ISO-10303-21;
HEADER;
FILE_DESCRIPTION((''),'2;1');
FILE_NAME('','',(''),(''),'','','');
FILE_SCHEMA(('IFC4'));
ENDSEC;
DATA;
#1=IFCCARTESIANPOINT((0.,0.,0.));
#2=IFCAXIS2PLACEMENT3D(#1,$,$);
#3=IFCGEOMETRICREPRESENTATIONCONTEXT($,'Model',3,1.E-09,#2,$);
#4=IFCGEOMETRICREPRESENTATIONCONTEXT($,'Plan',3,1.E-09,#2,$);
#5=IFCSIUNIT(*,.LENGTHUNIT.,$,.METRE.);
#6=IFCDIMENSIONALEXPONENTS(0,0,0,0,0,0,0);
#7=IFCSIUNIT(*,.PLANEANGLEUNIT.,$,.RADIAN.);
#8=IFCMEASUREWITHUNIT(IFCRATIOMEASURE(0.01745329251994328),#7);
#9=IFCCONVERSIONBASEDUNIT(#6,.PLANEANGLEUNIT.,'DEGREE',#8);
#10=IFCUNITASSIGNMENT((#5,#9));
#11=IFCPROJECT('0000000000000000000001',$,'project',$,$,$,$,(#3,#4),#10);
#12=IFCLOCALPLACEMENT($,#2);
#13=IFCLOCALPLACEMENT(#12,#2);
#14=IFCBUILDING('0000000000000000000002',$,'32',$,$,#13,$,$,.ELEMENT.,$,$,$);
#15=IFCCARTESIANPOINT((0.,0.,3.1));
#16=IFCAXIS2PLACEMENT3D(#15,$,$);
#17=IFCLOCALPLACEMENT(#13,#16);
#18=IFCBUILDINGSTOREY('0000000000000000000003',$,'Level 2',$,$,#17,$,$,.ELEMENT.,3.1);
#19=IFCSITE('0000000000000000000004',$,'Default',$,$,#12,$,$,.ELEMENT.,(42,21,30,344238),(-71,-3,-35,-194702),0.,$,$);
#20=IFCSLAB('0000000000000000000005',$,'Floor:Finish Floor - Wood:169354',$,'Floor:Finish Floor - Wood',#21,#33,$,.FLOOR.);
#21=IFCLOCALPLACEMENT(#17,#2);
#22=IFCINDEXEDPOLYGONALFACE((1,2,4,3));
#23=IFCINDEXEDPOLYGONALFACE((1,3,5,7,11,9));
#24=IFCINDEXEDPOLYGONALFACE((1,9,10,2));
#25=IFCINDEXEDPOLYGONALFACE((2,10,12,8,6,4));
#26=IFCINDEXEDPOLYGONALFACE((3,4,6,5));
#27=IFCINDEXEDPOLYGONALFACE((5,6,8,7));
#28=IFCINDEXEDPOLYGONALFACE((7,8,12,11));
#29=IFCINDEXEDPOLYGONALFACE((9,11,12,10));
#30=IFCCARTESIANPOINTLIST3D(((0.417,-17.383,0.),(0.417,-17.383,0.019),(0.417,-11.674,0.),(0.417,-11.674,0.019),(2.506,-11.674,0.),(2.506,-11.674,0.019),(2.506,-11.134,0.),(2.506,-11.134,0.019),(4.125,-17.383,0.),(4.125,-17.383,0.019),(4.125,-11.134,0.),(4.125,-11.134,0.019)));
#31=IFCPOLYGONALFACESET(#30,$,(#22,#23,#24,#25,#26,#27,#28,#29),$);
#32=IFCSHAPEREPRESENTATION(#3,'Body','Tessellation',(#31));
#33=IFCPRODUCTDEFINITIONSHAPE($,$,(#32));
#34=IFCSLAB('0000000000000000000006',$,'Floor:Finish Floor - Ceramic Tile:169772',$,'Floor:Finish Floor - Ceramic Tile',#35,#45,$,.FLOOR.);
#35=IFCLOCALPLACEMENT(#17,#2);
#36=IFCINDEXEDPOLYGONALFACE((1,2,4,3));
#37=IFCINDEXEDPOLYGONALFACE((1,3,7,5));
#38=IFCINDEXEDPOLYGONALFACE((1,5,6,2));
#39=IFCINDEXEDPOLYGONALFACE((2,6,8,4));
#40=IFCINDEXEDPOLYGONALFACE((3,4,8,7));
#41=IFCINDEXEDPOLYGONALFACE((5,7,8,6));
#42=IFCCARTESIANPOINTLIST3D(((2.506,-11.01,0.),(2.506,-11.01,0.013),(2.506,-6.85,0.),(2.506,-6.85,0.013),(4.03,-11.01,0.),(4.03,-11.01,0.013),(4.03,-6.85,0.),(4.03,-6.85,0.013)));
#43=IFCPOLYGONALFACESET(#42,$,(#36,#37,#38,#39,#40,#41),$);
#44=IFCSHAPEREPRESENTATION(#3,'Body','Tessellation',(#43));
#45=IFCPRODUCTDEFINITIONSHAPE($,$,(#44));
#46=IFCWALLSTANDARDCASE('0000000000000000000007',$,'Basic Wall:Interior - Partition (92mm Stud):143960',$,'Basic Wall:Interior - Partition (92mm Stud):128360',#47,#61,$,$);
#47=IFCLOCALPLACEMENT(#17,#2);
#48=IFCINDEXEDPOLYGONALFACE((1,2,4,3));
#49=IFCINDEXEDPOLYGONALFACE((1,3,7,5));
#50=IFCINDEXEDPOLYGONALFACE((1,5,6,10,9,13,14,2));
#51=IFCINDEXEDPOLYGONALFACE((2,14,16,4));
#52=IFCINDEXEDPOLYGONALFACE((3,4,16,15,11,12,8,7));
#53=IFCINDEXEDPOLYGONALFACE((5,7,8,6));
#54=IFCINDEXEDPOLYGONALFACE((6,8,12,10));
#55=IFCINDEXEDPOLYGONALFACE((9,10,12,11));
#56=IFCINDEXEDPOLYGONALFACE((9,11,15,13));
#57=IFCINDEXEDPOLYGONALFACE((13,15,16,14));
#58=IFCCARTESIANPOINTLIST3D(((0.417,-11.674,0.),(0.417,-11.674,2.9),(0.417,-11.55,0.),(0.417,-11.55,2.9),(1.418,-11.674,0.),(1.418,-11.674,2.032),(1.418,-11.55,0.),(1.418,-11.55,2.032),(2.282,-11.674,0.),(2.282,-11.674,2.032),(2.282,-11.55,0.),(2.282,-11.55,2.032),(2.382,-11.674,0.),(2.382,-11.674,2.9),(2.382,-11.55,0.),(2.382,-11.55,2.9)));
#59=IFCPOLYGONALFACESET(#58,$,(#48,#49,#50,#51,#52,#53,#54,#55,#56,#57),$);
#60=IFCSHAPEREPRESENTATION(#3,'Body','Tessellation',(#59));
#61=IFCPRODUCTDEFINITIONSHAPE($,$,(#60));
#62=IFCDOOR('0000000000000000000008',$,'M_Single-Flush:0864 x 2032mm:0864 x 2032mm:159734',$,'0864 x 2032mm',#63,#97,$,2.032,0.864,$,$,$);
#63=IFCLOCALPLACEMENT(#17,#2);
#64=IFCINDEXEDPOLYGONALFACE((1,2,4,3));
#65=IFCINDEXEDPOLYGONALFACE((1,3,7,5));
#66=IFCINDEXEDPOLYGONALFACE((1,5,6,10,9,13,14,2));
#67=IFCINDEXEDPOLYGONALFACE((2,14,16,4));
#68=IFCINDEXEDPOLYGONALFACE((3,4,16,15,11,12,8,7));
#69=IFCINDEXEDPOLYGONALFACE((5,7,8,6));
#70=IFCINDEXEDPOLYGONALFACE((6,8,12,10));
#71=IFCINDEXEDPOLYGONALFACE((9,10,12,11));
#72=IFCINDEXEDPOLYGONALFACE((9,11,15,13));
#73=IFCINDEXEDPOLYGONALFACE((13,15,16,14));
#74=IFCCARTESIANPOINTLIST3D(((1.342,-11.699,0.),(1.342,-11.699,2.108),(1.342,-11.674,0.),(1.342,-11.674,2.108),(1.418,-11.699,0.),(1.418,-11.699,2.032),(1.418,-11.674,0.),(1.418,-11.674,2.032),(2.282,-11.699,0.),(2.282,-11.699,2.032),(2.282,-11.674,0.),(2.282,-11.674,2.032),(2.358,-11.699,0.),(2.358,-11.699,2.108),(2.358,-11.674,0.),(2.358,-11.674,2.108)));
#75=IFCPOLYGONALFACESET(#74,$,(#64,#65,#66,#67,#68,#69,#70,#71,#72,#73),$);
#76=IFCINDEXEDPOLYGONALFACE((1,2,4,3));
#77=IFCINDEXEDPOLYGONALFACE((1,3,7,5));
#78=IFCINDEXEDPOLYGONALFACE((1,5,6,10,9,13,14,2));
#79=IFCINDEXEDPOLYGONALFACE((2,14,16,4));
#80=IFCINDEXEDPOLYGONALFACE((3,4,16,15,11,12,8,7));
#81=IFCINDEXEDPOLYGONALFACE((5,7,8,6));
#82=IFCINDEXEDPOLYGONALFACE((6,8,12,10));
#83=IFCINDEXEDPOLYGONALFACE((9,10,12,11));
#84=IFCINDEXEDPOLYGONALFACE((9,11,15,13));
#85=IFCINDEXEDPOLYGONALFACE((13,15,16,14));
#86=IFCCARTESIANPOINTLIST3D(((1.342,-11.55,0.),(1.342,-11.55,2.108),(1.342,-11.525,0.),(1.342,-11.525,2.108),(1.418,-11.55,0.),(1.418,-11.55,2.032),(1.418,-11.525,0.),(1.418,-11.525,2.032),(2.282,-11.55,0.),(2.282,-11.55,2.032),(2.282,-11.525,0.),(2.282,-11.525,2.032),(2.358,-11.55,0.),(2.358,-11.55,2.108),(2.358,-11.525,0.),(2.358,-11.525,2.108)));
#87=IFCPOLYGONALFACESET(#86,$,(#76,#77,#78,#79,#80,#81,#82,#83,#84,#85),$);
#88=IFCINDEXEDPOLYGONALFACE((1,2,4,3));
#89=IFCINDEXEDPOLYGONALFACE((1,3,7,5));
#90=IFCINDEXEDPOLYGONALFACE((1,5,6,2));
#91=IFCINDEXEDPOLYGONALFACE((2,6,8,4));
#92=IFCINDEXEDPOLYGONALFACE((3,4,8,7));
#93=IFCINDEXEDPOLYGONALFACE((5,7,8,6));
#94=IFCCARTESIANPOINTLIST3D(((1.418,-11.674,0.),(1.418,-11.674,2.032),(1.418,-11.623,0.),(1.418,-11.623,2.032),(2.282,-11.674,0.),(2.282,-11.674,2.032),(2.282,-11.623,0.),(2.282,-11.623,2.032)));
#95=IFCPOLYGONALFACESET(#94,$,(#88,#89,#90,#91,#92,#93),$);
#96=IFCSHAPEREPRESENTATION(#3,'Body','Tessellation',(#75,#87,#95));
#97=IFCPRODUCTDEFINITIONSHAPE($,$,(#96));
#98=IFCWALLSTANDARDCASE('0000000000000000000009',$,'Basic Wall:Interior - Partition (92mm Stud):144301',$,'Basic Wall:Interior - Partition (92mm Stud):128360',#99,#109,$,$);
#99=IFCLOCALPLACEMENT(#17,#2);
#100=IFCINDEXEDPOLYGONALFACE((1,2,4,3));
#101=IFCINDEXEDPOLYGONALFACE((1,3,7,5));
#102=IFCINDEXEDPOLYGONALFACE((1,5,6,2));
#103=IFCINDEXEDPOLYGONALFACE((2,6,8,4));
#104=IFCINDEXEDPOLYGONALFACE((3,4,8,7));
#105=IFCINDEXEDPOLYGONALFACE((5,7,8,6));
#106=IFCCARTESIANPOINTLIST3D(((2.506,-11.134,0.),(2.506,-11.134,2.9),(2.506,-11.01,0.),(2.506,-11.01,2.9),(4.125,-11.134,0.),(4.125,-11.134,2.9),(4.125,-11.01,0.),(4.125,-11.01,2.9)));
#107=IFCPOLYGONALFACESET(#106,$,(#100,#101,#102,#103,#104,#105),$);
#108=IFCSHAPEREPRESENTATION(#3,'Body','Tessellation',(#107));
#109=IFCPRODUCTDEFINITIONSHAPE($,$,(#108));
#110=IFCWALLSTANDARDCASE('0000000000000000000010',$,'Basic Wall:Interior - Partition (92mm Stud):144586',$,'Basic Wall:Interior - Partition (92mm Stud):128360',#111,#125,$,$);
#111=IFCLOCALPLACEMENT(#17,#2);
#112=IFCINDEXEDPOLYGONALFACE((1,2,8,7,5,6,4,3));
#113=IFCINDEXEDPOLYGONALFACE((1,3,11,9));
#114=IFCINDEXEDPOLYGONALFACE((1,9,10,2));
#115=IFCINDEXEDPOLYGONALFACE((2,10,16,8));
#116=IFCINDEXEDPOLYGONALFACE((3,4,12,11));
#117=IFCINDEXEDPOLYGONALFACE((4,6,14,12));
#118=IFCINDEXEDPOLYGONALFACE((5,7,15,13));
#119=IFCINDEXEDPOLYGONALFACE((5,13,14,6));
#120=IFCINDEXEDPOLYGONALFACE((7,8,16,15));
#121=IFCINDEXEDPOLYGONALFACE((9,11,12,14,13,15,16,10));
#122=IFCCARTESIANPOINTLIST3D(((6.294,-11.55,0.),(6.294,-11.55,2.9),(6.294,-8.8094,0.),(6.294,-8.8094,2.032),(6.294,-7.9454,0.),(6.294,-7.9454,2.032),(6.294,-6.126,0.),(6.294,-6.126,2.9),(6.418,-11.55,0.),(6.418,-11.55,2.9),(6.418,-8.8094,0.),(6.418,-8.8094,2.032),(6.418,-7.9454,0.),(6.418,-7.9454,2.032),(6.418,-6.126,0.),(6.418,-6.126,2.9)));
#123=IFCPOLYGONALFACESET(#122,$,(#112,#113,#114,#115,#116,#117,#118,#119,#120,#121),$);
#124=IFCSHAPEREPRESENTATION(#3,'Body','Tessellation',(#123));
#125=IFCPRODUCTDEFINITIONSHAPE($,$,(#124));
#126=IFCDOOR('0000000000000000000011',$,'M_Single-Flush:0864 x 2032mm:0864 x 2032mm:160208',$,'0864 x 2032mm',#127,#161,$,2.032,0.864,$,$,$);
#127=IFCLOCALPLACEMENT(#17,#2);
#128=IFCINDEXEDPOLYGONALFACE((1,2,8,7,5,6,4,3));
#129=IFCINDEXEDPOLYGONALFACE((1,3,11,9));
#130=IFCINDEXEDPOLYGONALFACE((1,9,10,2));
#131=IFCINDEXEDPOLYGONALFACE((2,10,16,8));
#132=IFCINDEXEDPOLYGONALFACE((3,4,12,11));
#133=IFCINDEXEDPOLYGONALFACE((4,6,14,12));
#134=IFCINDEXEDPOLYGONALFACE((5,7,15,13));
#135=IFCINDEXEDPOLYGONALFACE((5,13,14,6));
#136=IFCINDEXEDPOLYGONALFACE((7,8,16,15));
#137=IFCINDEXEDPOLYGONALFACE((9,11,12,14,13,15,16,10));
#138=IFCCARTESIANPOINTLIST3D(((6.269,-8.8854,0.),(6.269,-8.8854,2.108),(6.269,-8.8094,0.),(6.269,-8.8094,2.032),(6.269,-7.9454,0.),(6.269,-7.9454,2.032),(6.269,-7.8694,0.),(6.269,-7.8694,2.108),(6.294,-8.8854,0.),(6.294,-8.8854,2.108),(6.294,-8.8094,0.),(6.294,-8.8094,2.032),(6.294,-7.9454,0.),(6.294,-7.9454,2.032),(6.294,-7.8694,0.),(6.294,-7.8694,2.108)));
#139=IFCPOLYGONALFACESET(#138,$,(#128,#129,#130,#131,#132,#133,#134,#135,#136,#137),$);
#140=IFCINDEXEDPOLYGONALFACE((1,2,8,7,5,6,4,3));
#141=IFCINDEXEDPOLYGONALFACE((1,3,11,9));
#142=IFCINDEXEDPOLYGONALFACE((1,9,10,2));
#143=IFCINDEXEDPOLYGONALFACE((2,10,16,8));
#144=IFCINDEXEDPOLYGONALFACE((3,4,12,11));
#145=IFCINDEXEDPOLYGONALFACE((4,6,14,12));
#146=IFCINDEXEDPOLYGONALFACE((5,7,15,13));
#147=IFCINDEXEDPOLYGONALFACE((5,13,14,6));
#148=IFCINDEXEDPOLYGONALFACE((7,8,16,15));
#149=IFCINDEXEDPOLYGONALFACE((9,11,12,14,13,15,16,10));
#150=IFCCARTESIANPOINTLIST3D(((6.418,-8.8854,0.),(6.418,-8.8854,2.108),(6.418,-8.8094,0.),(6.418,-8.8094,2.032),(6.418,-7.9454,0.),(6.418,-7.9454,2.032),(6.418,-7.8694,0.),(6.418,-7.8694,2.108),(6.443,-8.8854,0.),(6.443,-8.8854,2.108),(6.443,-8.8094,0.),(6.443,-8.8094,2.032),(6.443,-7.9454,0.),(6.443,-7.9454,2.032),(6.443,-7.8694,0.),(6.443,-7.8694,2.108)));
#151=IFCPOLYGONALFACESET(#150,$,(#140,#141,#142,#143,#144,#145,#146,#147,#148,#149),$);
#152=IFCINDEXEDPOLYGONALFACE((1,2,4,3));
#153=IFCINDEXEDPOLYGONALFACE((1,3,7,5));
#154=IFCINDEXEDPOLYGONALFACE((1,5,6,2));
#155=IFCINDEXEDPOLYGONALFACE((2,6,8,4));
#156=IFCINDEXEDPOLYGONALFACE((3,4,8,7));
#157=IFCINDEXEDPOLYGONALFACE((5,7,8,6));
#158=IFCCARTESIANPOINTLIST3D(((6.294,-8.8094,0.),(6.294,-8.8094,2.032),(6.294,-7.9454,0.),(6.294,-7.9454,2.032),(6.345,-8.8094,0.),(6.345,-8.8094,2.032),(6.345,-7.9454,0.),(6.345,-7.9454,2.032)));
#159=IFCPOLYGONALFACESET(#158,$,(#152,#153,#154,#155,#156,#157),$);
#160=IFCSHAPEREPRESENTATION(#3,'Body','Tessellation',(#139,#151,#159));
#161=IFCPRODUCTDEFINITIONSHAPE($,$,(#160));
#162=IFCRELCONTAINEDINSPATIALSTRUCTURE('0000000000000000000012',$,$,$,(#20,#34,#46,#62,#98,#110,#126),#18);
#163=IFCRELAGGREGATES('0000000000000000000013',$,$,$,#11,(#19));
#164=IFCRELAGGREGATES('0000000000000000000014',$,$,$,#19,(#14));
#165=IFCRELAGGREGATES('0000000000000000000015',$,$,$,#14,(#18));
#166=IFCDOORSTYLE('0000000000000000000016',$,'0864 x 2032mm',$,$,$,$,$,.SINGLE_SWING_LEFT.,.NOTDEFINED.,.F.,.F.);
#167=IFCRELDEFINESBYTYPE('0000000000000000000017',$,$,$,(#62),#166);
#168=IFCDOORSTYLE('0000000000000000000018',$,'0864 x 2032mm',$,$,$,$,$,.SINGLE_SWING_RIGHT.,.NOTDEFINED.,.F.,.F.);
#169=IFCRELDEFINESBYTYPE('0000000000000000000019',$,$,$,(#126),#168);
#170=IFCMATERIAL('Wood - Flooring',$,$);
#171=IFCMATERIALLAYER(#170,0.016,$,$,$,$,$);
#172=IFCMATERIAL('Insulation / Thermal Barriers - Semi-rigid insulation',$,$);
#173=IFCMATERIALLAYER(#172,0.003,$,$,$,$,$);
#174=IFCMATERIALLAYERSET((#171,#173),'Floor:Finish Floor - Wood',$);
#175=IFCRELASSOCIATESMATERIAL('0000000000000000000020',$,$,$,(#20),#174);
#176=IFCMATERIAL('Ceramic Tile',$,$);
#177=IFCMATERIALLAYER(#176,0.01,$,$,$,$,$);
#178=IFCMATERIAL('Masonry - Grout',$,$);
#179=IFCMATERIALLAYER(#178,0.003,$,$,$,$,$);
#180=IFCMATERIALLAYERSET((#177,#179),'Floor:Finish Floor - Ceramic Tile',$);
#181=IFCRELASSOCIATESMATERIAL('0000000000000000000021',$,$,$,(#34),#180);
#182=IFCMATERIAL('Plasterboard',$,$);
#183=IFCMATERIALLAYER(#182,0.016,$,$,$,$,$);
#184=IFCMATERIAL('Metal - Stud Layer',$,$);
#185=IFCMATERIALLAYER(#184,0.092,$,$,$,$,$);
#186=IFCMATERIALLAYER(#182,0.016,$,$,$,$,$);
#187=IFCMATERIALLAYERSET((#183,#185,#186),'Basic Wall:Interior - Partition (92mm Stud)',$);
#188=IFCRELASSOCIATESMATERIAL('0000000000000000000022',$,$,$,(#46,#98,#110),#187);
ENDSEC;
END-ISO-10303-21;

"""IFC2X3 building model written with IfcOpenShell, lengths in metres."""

from ifc_helpers import new_model, entity, si_unit, converted_unit, frame, frame_2d, origin, origin_2d_with_axis, place, context, project, spatial, polyline, rectangle, outline, extrude, source, transform, mapped, material, layer, layer_set, layer_usage, type_object, type_shapes, element, fill, save


model = new_model("IFC2X3")

# Units and contexts
model_context = context("Model", 3, precision=1e-09, world=origin())
plan_context = context("Plan", 3, precision=1e-09, world=origin())
ifc_project = project(units=[si_unit("LENGTHUNIT", "METRE"), converted_unit("PLANEANGLEUNIT", "DEGREE", entity("IfcRatioMeasure", 0.01745329251994328), si_unit("PLANEANGLEUNIT", "RADIAN"), dimensions=[0, 0, 0, 0, 0, 0, 0])], contexts=[model_context, plan_context])

# Site, building, storey
site_placement = place(None, origin())
site = spatial("IfcSite", under=ifc_project, at=site_placement, Name="Default", CompositionType="ELEMENT", RefLatitude=(42, 21, 30, 344238), RefLongitude=(-71, -3, -35, -194702), RefElevation=0.0)
building_placement = place(site_placement, origin())
building = spatial("IfcBuilding", under=site, at=building_placement, Name="32", CompositionType="ELEMENT")
storey_placement = place(building_placement, frame((0.0, 0.0, 3.1)))
storey = spatial("IfcBuildingStorey", under=building, at=storey_placement, Name="Level 2", CompositionType="ELEMENT", Elevation=3.1)

# Slabs
ifc_material_1 = material(Name="Wood - Flooring")
ifc_layer_1 = layer(ifc_material_1, 0.016)
ifc_material_2 = material(Name="Insulation / Thermal Barriers - Semi-rigid insulation")
ifc_layer_2 = layer(ifc_material_2, 0.003)
ifc_layer_set_1 = layer_set([ifc_layer_1, ifc_layer_2], Name="Floor:Finish Floor - Wood")
ifc_layer_usage_1 = layer_usage(ifc_layer_set_1, "AXIS3", "POSITIVE", 0.0)
slab_1_placement = place(storey_placement, frame((0.417, -17.383, 0.0)))
element("IfcSlab", 1, at=slab_1_placement, inside=storey, material=ifc_layer_usage_1, Name="Floor:Finish Floor - Wood:169354", ObjectType="Floor:Finish Floor - Wood", PredefinedType="FLOOR", context=model_context, shape_type="SweptSolid", body=[
    extrude(outline(polyline([(-1.854, -3.1245), (1.854, -3.1245), (1.854, 2.5845), (-0.235, 2.5845), (-0.235, 3.1245), (-1.854, 3.1245), (-1.854, -3.1245)])), frame((1.854, 3.1245, 0.019), z_axis=(0.0, 0.0, -1.0), x_axis=(-1.0, 0.0, 0.0)), (0.0, 0.0, 1.0), 0.019),
])
ifc_material_3 = material(Name="Ceramic Tile")
ifc_layer_3 = layer(ifc_material_3, 0.01)
ifc_material_4 = material(Name="Masonry - Grout")
ifc_layer_4 = layer(ifc_material_4, 0.003)
ifc_layer_set_2 = layer_set([ifc_layer_3, ifc_layer_4], Name="Floor:Finish Floor - Ceramic Tile")
ifc_layer_usage_2 = layer_usage(ifc_layer_set_2, "AXIS3", "POSITIVE", 0.0)
slab_2_placement = place(storey_placement, frame((2.506, -11.01, 0.0)))
element("IfcSlab", 2, at=slab_2_placement, inside=storey, material=ifc_layer_usage_2, Name="Floor:Finish Floor - Ceramic Tile:169772", ObjectType="Floor:Finish Floor - Ceramic Tile", PredefinedType="FLOOR", context=model_context, shape_type="SweptSolid", body=[
    extrude(rectangle(XDim=4.16, YDim=1.524, at=frame_2d((0.0, 0.0), x_axis=(0.0, -1.0))), frame((0.762, 2.08, 0.013), z_axis=(0.0, 0.0, -1.0), x_axis=(-1.0, 0.0, 0.0)), (0.0, 0.0, 1.0), 0.013),
])

# Shared definitions
ifc_material_5 = material(Name="Metal - Stud Layer")
ifc_material_6 = material(Name="Plasterboard")

# Wall, opening, door
ifc_layer_5 = layer(ifc_material_6, 0.016)
ifc_layer_6 = layer(ifc_material_5, 0.092)
ifc_layer_7 = layer(ifc_material_6, 0.016)
ifc_layer_set_3 = layer_set([ifc_layer_5, ifc_layer_6, ifc_layer_7], Name="Basic Wall:Interior - Partition (92mm Stud)")
ifc_layer_usage_3 = layer_usage(ifc_layer_set_3, "AXIS2", "NEGATIVE", 0.062)
wall_1_placement = place(storey_placement, frame((2.382, -11.612, 0.0), z_axis=(0.0, 0.0, 1.0), x_axis=(-1.0, 0.0, 0.0)))
wall_1 = element("IfcWallStandardCase", 3, at=wall_1_placement, inside=storey, material=ifc_layer_usage_3, Name="Basic Wall:Interior - Partition (92mm Stud):143960", ObjectType="Basic Wall:Interior - Partition (92mm Stud):128360", context=model_context, shape_type="SweptSolid", body=[
    extrude(rectangle(XDim=1.965, YDim=0.124, at=frame_2d((0.9825, 0.0), x_axis=(-1.0, 0.0))), origin(), (0.0, 0.0, 1.0), 2.9),
])
opening_1_placement = place(wall_1_placement, frame((0.1, -0.062, 0.0)))
opening_1 = element("IfcOpeningElement", 4, at=opening_1_placement, cuts=wall_1, ObjectType="Opening", context=model_context, shape_type="SweptSolid", body=[
    extrude(rectangle(XDim=0.864, YDim=2.032, at=frame_2d((1.016, 0.432), x_axis=(0.0, -1.0))), frame((0.0, 0.0, 0.0), z_axis=(0.0, 1.0, 0.0), x_axis=(0.0, 0.0, 1.0)), (0.0, 0.0, 1.0), 0.124),
])
door_style_1 = type_object("IfcDoorStyle", Name="0864 x 2032mm", ConstructionType="NOTDEFINED", OperationType="SINGLE_SWING_LEFT", ParameterTakesPrecedence=False, Sizeable=False)
shared_shape_1 = source(origin(), model_context, "Body", "SweptSolid", [
    extrude(outline(polyline([(-0.508, -1.073), (0.508, -1.073), (0.508, 1.035), (0.432, 1.035), (0.432, -0.997), (-0.432, -0.997), (-0.432, 1.035), (-0.508, 1.035), (-0.508, -1.073)])), frame((0.432, 0.149, 1.035), z_axis=(0.0, -1.0, 0.0), x_axis=(-1.0, 0.0, 0.0)), (0.0, 0.0, 1.0), 0.025),
    extrude(outline(polyline([(-1.073, -0.508), (1.035, -0.508), (1.035, -0.432), (-0.997, -0.432), (-0.997, 0.432), (1.035, 0.432), (1.035, 0.508), (-1.073, 0.508), (-1.073, -0.508)])), frame((0.432, 0.0, 1.035), z_axis=(0.0, -1.0, 0.0), x_axis=(0.0, 0.0, -1.0)), (0.0, 0.0, 1.0), 0.025),
    extrude(rectangle(XDim=0.864, YDim=0.051, at=origin_2d_with_axis()), frame((0.432, 0.0985, 0.0)), (0.0, 0.0, 1.0), 2.032),
])
type_shapes(door_style_1, [shared_shape_1])
door_1_placement = place(opening_1_placement, origin())
door_1 = element("IfcDoor", 5, at=door_1_placement, inside=storey, type_object=door_style_1, Name="M_Single-Flush:0864 x 2032mm:0864 x 2032mm:159734", ObjectType="0864 x 2032mm", OverallHeight=2.032, OverallWidth=0.864, context=model_context, shape_type="MappedRepresentation", body=[
    mapped(shared_shape_1, transform((0.0, 0.0, 0.0), scale=1.0)),
])
fill(opening_1, door_1)

# Wall
ifc_layer_usage_4 = layer_usage(ifc_layer_set_3, "AXIS2", "NEGATIVE", 0.062)
wall_2_placement = place(storey_placement, frame((4.125, -11.072, 0.0), z_axis=(0.0, 0.0, 1.0), x_axis=(-1.0, 0.0, 0.0)))
element("IfcWallStandardCase", 6, at=wall_2_placement, inside=storey, material=ifc_layer_usage_4, Name="Basic Wall:Interior - Partition (92mm Stud):144301", ObjectType="Basic Wall:Interior - Partition (92mm Stud):128360", context=model_context, shape_type="SweptSolid", body=[
    extrude(rectangle(XDim=1.619, YDim=0.124, at=frame_2d((0.8095, 0.0), x_axis=(-1.0, 0.0))), origin(), (0.0, 0.0, 1.0), 2.9),
])

# Wall, opening, door
ifc_layer_usage_5 = layer_usage(ifc_layer_set_3, "AXIS2", "NEGATIVE", 0.062)
wall_3_placement = place(storey_placement, frame((6.356, -11.55, 0.0), z_axis=(0.0, 0.0, 1.0), x_axis=(0.0, 1.0, 0.0)))
wall_3 = element("IfcWallStandardCase", 7, at=wall_3_placement, inside=storey, material=ifc_layer_usage_5, Name="Basic Wall:Interior - Partition (92mm Stud):144586", ObjectType="Basic Wall:Interior - Partition (92mm Stud):128360", context=model_context, shape_type="SweptSolid", body=[
    extrude(rectangle(XDim=5.424, YDim=0.124, at=frame_2d((2.712, 0.0), x_axis=(-1.0, 0.0))), origin(), (0.0, 0.0, 1.0), 2.9),
])
opening_2_placement = place(wall_3_placement, frame((2.7406, -0.062, 0.0)))
opening_2 = element("IfcOpeningElement", 8, at=opening_2_placement, cuts=wall_3, ObjectType="Opening", context=model_context, shape_type="SweptSolid", body=[
    extrude(rectangle(XDim=0.864, YDim=2.032, at=frame_2d((1.016, 0.432), x_axis=(0.0, 1.0))), frame((0.0, 0.0, 0.0), z_axis=(0.0, 1.0, 0.0), x_axis=(0.0, 0.0, 1.0)), (0.0, 0.0, 1.0), 0.124),
])
door_style_2 = type_object("IfcDoorStyle", Name="0864 x 2032mm", ConstructionType="NOTDEFINED", OperationType="SINGLE_SWING_RIGHT", ParameterTakesPrecedence=False, Sizeable=False)
shared_shape_2 = source(origin(), model_context, "Body", "SweptSolid", [
    extrude(outline(polyline([(-0.508, -1.073), (0.508, -1.073), (0.508, 1.035), (0.432, 1.035), (0.432, -0.997), (-0.432, -0.997), (-0.432, 1.035), (-0.508, 1.035), (-0.508, -1.073)])), frame((0.432, 0.124, 1.035), z_axis=(0.0, 1.0, 0.0), x_axis=(1.0, 0.0, 0.0)), (0.0, 0.0, 1.0), 0.025),
    extrude(outline(polyline([(-1.073, -0.508), (1.035, -0.508), (1.035, -0.432), (-0.997, -0.432), (-0.997, 0.432), (1.035, 0.432), (1.035, 0.508), (-1.073, 0.508), (-1.073, -0.508)])), frame((0.432, -0.025, 1.035), z_axis=(0.0, 1.0, 0.0), x_axis=(0.0, 0.0, -1.0)), (0.0, 0.0, 1.0), 0.025),
    extrude(rectangle(XDim=0.051, YDim=0.864, at=origin_2d_with_axis()), frame((0.432, 0.0985, 0.0), z_axis=(0.0, 0.0, 1.0), x_axis=(0.0, 1.0, 0.0)), (0.0, 0.0, 1.0), 2.032),
])
type_shapes(door_style_2, [shared_shape_2])
door_2_placement = place(opening_2_placement, origin())
door_2 = element("IfcDoor", 9, at=door_2_placement, inside=storey, type_object=door_style_2, Name="M_Single-Flush:0864 x 2032mm:0864 x 2032mm:160208", ObjectType="0864 x 2032mm", OverallHeight=2.032, OverallWidth=0.864, context=model_context, shape_type="MappedRepresentation", body=[
    mapped(shared_shape_2, transform((0.0, 0.0, 0.0), scale=1.0)),
])
fill(opening_2, door_2)

save(model, "model.ifc")
